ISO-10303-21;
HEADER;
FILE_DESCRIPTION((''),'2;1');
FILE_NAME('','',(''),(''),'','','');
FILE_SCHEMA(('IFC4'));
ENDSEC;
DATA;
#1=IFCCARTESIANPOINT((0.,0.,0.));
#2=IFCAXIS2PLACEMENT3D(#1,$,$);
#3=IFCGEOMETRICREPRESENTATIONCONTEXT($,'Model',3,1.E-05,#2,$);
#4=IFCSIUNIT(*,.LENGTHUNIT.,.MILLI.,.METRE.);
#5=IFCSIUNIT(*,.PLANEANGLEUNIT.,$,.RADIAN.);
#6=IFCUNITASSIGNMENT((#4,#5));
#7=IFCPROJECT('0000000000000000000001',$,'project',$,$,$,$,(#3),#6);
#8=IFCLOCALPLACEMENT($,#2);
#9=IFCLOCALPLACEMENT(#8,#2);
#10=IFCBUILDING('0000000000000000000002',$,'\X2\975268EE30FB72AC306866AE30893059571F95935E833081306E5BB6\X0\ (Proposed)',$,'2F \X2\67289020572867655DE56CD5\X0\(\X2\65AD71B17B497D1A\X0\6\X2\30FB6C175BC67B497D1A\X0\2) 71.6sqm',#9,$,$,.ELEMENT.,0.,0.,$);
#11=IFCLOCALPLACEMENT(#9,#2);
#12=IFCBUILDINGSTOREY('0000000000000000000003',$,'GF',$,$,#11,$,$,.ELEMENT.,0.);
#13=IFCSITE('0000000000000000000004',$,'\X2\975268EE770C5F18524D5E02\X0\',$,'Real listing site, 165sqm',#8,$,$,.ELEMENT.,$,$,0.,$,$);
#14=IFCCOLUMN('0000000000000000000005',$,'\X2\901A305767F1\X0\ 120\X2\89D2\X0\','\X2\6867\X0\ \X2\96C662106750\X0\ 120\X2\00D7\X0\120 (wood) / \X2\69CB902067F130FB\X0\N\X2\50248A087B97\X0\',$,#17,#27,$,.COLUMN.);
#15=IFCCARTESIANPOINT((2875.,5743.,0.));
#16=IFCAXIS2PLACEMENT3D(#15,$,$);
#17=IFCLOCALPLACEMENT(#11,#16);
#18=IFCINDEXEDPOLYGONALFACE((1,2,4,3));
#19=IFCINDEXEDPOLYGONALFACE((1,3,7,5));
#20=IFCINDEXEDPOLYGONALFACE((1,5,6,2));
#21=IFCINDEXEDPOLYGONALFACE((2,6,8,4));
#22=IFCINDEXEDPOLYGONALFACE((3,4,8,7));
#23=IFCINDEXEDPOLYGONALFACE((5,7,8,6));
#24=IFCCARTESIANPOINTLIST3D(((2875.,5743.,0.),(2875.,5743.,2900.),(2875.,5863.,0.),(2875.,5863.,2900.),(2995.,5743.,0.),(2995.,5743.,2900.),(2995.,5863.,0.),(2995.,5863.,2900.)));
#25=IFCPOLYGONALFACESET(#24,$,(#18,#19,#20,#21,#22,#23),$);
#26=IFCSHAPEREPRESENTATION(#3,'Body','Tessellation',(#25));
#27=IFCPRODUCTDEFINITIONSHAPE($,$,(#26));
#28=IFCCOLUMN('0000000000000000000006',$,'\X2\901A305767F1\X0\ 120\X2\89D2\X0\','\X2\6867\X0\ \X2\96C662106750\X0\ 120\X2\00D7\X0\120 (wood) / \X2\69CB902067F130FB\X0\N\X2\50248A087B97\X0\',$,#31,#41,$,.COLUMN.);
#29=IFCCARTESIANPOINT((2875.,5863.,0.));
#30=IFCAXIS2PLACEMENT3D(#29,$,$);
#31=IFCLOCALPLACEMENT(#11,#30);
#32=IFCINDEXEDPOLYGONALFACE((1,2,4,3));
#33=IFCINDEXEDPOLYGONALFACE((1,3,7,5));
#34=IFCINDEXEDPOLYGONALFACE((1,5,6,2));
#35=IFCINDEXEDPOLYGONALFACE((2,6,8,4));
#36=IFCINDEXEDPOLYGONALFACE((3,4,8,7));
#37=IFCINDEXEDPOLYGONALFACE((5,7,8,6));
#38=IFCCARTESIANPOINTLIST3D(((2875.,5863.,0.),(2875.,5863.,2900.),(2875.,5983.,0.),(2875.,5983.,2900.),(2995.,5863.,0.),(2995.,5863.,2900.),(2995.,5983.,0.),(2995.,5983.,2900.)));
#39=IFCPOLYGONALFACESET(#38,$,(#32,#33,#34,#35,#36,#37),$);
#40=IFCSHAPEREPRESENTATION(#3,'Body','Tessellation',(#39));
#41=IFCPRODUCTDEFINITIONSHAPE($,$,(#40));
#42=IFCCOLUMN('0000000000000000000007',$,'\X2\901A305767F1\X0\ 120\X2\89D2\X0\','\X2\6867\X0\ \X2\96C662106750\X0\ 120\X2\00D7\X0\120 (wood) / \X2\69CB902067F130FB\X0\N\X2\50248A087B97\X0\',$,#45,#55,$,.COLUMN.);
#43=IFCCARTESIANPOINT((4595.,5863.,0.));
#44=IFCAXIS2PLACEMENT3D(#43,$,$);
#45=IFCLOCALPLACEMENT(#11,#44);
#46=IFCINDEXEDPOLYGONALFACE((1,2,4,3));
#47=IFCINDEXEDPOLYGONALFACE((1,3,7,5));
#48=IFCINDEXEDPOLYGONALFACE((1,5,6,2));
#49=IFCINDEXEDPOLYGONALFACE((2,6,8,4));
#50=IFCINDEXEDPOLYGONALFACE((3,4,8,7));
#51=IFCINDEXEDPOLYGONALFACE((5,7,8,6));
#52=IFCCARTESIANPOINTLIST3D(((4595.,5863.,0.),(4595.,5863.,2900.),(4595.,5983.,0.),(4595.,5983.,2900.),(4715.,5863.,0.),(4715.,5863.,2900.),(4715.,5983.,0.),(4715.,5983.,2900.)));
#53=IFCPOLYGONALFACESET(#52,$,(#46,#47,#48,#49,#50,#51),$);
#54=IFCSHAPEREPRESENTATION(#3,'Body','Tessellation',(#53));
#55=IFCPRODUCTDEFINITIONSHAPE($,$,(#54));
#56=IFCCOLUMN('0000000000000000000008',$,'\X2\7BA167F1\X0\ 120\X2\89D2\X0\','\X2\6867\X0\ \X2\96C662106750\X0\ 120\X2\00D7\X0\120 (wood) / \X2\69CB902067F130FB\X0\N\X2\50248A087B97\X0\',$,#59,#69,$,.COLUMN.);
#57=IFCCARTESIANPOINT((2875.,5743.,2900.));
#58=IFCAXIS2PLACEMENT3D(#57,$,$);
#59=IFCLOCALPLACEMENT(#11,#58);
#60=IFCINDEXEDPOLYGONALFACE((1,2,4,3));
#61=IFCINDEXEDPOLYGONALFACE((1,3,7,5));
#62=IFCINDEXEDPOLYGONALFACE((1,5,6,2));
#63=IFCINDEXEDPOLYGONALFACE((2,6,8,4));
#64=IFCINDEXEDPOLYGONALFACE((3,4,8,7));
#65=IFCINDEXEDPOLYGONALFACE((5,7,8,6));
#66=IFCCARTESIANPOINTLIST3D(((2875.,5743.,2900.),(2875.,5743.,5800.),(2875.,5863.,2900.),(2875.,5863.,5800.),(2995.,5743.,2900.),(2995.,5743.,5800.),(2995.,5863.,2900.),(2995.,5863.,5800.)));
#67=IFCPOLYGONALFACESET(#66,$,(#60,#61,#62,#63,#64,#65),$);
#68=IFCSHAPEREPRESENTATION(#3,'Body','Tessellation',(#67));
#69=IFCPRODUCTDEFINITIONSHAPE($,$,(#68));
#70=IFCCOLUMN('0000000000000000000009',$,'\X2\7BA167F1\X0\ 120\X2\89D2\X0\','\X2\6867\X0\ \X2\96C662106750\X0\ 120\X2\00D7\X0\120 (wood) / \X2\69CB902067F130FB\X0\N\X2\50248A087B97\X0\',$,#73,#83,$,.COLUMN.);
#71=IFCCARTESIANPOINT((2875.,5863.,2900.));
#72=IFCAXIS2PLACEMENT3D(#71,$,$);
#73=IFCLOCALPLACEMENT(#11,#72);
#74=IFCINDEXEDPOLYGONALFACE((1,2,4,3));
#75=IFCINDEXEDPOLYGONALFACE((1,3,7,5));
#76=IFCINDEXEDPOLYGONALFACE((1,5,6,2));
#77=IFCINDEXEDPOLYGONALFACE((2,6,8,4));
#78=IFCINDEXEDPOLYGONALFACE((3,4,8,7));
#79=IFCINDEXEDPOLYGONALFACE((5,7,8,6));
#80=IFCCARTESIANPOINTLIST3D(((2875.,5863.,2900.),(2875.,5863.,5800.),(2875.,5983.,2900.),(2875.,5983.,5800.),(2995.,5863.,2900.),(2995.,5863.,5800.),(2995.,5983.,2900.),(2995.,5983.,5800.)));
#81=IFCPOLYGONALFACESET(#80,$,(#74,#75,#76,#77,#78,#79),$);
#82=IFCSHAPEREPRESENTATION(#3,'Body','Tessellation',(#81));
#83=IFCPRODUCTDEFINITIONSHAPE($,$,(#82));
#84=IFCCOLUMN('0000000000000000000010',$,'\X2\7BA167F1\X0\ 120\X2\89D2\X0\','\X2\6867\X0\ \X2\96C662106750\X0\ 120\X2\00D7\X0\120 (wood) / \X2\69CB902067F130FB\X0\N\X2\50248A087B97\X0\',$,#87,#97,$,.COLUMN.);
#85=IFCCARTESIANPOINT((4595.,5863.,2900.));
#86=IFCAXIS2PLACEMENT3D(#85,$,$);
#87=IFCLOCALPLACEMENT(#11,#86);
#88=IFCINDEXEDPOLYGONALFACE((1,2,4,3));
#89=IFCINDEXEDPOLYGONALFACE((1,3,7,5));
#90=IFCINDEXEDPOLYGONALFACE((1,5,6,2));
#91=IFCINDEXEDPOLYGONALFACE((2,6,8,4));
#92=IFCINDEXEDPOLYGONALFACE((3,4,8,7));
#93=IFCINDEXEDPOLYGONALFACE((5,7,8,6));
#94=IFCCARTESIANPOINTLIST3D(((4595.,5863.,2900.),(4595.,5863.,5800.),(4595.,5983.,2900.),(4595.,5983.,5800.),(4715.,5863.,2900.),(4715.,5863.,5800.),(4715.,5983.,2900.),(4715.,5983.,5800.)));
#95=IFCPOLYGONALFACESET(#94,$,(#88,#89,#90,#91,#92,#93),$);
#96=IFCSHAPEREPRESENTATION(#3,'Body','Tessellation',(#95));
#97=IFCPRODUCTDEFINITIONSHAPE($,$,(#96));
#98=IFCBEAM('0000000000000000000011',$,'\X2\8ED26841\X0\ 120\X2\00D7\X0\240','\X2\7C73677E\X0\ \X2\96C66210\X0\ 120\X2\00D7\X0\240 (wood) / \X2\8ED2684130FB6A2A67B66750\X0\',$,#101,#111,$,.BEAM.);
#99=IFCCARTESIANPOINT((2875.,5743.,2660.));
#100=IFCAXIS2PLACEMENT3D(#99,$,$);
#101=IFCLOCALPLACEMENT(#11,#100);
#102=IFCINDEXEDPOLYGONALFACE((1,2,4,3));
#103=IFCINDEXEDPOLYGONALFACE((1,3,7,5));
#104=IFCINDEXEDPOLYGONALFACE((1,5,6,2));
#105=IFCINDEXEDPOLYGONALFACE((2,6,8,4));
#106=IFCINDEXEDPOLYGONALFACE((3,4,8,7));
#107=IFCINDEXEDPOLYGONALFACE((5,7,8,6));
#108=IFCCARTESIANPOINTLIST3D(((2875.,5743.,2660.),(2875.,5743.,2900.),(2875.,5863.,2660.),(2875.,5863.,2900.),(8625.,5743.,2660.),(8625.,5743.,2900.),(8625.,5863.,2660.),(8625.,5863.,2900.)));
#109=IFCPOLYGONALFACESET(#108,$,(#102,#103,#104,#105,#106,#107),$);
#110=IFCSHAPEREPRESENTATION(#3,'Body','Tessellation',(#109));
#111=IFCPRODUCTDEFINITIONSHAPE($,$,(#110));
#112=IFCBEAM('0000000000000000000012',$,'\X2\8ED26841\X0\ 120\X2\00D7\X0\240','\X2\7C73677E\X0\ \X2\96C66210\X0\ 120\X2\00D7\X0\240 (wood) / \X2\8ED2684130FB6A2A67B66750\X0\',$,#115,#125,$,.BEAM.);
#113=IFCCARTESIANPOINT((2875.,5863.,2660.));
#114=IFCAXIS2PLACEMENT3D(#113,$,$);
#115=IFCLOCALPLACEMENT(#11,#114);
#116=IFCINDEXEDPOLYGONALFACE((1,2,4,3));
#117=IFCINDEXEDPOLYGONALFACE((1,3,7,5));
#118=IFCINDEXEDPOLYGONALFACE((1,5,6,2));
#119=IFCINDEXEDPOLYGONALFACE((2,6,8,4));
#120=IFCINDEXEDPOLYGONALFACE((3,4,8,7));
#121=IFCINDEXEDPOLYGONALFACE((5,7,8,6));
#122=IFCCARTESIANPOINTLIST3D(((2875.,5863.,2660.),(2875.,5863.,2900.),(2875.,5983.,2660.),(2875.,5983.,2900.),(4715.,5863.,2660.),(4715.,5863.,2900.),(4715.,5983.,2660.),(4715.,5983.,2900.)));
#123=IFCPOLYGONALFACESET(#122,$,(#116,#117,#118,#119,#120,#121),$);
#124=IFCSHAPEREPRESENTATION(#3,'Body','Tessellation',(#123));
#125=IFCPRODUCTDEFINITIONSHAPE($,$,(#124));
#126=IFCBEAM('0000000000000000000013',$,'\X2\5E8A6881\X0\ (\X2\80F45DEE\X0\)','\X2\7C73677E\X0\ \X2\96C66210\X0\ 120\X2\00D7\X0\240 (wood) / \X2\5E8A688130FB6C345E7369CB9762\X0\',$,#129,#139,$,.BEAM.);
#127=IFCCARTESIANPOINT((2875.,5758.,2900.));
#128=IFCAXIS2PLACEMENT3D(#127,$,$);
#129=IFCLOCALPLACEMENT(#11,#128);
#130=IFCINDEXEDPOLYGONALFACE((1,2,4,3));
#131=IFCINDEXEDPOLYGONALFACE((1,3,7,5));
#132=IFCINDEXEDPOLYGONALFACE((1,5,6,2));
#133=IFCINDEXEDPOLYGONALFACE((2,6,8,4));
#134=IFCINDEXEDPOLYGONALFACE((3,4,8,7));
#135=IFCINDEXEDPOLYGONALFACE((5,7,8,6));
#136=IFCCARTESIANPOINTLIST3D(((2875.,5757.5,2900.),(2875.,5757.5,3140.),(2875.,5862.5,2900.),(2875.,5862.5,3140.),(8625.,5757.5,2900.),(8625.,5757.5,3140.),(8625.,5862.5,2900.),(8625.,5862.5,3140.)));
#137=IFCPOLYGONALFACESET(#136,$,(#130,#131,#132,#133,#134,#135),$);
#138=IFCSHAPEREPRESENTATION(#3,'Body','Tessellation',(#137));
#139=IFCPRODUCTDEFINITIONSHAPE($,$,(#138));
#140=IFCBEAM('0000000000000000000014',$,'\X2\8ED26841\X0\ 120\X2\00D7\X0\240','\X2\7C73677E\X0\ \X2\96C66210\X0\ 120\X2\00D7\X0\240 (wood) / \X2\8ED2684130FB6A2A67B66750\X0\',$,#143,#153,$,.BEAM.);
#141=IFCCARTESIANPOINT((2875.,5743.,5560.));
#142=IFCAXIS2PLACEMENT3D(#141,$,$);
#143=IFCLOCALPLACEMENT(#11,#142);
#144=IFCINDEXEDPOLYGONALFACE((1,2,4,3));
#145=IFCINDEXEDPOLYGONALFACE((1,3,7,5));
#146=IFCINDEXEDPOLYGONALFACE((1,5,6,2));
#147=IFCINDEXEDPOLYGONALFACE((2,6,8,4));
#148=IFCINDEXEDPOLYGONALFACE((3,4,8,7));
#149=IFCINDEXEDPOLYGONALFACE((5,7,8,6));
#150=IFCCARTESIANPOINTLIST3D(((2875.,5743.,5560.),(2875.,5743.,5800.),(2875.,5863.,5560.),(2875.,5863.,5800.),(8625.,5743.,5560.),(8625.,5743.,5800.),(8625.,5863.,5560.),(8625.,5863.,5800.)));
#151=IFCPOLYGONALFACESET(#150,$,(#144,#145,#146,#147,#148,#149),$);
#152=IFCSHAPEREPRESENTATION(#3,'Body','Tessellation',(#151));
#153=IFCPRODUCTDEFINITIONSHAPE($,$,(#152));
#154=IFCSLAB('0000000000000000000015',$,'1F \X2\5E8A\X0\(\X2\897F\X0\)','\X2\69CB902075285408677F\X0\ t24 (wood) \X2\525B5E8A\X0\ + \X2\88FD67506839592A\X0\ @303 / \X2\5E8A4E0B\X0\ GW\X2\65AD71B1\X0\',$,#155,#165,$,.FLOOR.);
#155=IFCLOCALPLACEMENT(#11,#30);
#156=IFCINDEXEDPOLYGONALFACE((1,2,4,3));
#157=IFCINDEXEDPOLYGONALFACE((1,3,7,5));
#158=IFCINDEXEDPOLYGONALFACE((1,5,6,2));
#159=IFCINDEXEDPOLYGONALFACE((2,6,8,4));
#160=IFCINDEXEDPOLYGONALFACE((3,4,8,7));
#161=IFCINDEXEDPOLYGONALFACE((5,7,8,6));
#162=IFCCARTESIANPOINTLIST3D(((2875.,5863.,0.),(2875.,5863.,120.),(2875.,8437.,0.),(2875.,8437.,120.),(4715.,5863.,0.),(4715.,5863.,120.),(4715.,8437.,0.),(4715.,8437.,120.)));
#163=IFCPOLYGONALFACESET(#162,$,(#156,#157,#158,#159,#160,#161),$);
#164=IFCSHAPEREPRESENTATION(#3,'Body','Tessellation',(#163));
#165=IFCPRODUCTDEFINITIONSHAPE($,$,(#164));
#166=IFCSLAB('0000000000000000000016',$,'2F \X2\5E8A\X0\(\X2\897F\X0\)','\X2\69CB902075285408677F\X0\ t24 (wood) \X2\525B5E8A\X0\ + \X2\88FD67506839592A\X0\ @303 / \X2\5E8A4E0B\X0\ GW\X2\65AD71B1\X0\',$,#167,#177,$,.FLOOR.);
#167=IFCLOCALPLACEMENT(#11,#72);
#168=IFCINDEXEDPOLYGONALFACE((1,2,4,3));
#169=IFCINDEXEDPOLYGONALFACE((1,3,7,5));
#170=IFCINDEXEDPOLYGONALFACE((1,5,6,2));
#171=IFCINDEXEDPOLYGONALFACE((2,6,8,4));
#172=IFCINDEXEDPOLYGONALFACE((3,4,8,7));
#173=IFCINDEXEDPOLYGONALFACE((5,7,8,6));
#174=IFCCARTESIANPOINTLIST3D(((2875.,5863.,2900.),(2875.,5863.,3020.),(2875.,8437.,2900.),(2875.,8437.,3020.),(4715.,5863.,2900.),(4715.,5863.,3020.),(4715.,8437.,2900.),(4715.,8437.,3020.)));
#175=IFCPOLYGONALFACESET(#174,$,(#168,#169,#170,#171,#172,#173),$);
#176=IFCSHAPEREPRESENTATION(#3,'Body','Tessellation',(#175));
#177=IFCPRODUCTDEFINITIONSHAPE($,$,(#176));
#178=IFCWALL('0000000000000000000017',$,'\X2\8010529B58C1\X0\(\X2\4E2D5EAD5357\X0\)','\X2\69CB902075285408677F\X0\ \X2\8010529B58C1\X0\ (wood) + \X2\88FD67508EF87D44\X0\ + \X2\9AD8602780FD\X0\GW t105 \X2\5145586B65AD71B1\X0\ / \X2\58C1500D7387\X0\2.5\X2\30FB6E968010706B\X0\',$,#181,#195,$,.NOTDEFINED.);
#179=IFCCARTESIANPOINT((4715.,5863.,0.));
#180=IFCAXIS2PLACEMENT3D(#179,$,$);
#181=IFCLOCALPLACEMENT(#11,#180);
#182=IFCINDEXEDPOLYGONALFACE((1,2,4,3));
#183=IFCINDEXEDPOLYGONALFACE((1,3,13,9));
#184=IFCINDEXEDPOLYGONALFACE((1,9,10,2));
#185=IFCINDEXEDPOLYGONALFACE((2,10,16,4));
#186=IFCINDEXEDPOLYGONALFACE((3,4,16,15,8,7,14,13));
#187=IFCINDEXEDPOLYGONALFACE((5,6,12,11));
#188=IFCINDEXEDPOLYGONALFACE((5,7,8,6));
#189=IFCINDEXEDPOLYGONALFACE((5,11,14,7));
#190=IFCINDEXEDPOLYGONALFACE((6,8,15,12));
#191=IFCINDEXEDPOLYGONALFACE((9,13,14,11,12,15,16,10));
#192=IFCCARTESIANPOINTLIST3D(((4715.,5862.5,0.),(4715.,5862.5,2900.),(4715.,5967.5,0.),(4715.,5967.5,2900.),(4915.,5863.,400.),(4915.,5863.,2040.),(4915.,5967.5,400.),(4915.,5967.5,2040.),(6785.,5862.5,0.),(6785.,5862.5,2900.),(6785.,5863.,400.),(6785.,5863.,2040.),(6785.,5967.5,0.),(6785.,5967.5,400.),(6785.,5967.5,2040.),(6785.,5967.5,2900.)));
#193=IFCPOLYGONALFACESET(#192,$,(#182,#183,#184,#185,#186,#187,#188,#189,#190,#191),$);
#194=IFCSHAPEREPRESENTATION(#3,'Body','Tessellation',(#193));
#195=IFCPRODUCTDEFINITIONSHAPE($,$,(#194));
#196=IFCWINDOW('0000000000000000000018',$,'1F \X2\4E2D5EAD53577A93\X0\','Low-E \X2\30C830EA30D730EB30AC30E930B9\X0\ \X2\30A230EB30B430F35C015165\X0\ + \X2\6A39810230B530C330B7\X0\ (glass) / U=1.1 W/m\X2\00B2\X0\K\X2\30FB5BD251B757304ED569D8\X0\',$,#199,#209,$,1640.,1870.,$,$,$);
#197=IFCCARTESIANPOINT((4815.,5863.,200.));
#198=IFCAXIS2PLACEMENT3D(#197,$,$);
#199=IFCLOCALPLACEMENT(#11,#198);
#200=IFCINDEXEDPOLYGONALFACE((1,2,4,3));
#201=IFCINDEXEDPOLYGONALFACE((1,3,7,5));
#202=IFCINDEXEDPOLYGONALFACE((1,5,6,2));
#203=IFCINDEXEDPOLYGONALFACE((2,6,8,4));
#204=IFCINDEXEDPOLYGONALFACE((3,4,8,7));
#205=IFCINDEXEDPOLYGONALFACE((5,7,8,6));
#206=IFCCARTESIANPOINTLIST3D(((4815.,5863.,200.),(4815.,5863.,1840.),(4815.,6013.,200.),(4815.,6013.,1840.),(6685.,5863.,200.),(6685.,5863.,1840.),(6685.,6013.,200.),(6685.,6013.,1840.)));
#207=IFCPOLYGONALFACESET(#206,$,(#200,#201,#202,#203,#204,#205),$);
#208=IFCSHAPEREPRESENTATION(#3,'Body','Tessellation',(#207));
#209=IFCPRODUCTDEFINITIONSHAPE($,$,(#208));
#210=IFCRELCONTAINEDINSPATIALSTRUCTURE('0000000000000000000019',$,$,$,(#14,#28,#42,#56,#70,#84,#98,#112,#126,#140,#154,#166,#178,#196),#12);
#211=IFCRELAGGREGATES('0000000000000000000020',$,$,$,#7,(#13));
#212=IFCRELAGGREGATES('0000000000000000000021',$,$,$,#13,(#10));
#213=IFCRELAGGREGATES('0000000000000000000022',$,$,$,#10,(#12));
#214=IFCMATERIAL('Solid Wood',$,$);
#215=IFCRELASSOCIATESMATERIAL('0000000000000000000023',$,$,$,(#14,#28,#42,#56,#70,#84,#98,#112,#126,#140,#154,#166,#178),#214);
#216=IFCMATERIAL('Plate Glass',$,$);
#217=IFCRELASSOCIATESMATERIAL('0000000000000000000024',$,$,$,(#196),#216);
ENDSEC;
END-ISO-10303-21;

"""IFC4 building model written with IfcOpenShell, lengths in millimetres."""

from ifc_helpers import new_model, si_unit, frame, frame_2d, origin, place, context, project, spatial, rectangle, extrude, material, element, fill, save


model = new_model("IFC4")

# Units and contexts
model_context = context("Model", 3, precision=1e-05, world=origin())
ifc_project = project(units=[si_unit("LENGTHUNIT", "METRE", prefix="MILLI"), si_unit("PLANEANGLEUNIT", "RADIAN")], contexts=[model_context])

# Site, building, storey
site_placement = place(None, origin())
site = spatial("IfcSite", under=ifc_project, at=site_placement, Name="青森県弘前市", ObjectType="Real listing site, 165sqm", CompositionType="ELEMENT", RefElevation=0.0)
building_placement = place(site_placement, origin())
building = spatial("IfcBuilding", under=site, at=building_placement, Name="青森・犬と暮らす土間広めの家 (Proposed)", ObjectType="2F 木造在来工法(断熱等級6・気密等級2) 71.6sqm", CompositionType="ELEMENT", ElevationOfRefHeight=0.0, ElevationOfTerrain=0.0)
storey_placement = place(building_placement, origin())
storey = spatial("IfcBuildingStorey", under=building, at=storey_placement, Name="GF", CompositionType="ELEMENT", Elevation=0.0)

# Columns
ifc_material_1 = material(Name="Solid Wood")
column_1_placement = place(storey_placement, frame((2875.0, 5743.0, 0.0)))
element("IfcColumn", 1, at=column_1_placement, inside=storey, material=ifc_material_1, Name="通し柱 120角", Description="桧 集成材 120×120 (wood) / 構造柱・N値計算", PredefinedType="COLUMN", context=model_context, shape_type="SweptSolid", body=[
    extrude(rectangle(XDim=120.0, YDim=120.0, at=frame_2d((60.0, 60.0))), frame((2875.0, 5743.0, 0.0)), (0.0, 0.0, 1.0), 2900.0),
])
column_2_placement = place(storey_placement, frame((2875.0, 5863.0, 0.0)))
element("IfcColumn", 2, at=column_2_placement, inside=storey, material=ifc_material_1, Name="通し柱 120角", Description="桧 集成材 120×120 (wood) / 構造柱・N値計算", PredefinedType="COLUMN", context=model_context, shape_type="SweptSolid", body=[
    extrude(rectangle(XDim=120.0, YDim=120.0, at=frame_2d((60.0, 60.0))), frame((2875.0, 5863.0, 0.0)), (0.0, 0.0, 1.0), 2900.0),
])
column_3_placement = place(storey_placement, frame((4595.0, 5863.0, 0.0)))
element("IfcColumn", 3, at=column_3_placement, inside=storey, material=ifc_material_1, Name="通し柱 120角", Description="桧 集成材 120×120 (wood) / 構造柱・N値計算", PredefinedType="COLUMN", context=model_context, shape_type="SweptSolid", body=[
    extrude(rectangle(XDim=120.0, YDim=120.0, at=frame_2d((60.0, 60.0))), frame((4595.0, 5863.0, 0.0)), (0.0, 0.0, 1.0), 2900.0),
])
column_4_placement = place(storey_placement, frame((2875.0, 5743.0, 2900.0)))
element("IfcColumn", 4, at=column_4_placement, inside=storey, material=ifc_material_1, Name="管柱 120角", Description="桧 集成材 120×120 (wood) / 構造柱・N値計算", PredefinedType="COLUMN", context=model_context, shape_type="SweptSolid", body=[
    extrude(rectangle(XDim=120.0, YDim=120.0, at=frame_2d((60.0, 60.0))), frame((2875.0, 5743.0, 2900.0)), (0.0, 0.0, 1.0), 2900.0),
])
column_5_placement = place(storey_placement, frame((2875.0, 5863.0, 2900.0)))
element("IfcColumn", 5, at=column_5_placement, inside=storey, material=ifc_material_1, Name="管柱 120角", Description="桧 集成材 120×120 (wood) / 構造柱・N値計算", PredefinedType="COLUMN", context=model_context, shape_type="SweptSolid", body=[
    extrude(rectangle(XDim=120.0, YDim=120.0, at=frame_2d((60.0, 60.0))), frame((2875.0, 5863.0, 2900.0)), (0.0, 0.0, 1.0), 2900.0),
])
column_6_placement = place(storey_placement, frame((4595.0, 5863.0, 2900.0)))
element("IfcColumn", 6, at=column_6_placement, inside=storey, material=ifc_material_1, Name="管柱 120角", Description="桧 集成材 120×120 (wood) / 構造柱・N値計算", PredefinedType="COLUMN", context=model_context, shape_type="SweptSolid", body=[
    extrude(rectangle(XDim=120.0, YDim=120.0, at=frame_2d((60.0, 60.0))), frame((4595.0, 5863.0, 2900.0)), (0.0, 0.0, 1.0), 2900.0),
])

# Beams
beam_1_placement = place(storey_placement, frame((2875.0, 5743.0, 2660.0)))
element("IfcBeam", 7, at=beam_1_placement, inside=storey, material=ifc_material_1, Name="軒桁 120×240", Description="米松 集成 120×240 (wood) / 軒桁・横架材", PredefinedType="BEAM", context=model_context, shape_type="SweptSolid", body=[
    extrude(rectangle(XDim=5750.0, YDim=120.0, at=frame_2d((2875.0, 60.0))), frame((2875.0, 5743.0, 2660.0)), (0.0, 0.0, 1.0), 240.0),
])
beam_2_placement = place(storey_placement, frame((2875.0, 5863.0, 2660.0)))
element("IfcBeam", 8, at=beam_2_placement, inside=storey, material=ifc_material_1, Name="軒桁 120×240", Description="米松 集成 120×240 (wood) / 軒桁・横架材", PredefinedType="BEAM", context=model_context, shape_type="SweptSolid", body=[
    extrude(rectangle(XDim=1840.0, YDim=120.0, at=frame_2d((920.0, 60.0))), frame((2875.0, 5863.0, 2660.0)), (0.0, 0.0, 1.0), 240.0),
])
beam_3_placement = place(storey_placement, frame((2875.0, 5758.0, 2900.0)))
element("IfcBeam", 9, at=beam_3_placement, inside=storey, material=ifc_material_1, Name="床梁 (胴差)", Description="米松 集成 120×240 (wood) / 床梁・水平構面", PredefinedType="BEAM", context=model_context, shape_type="SweptSolid", body=[
    extrude(rectangle(XDim=5750.0, YDim=105.0, at=frame_2d((2875.0, 52.0))), frame((2875.0, 5758.0, 2900.0)), (0.0, 0.0, 1.0), 240.0),
])
beam_4_placement = place(storey_placement, frame((2875.0, 5743.0, 5560.0)))
element("IfcBeam", 10, at=beam_4_placement, inside=storey, material=ifc_material_1, Name="軒桁 120×240", Description="米松 集成 120×240 (wood) / 軒桁・横架材", PredefinedType="BEAM", context=model_context, shape_type="SweptSolid", body=[
    extrude(rectangle(XDim=5750.0, YDim=120.0, at=frame_2d((2875.0, 60.0))), frame((2875.0, 5743.0, 5560.0)), (0.0, 0.0, 1.0), 240.0),
])

# Slabs
slab_1_placement = place(storey_placement, frame((2875.0, 5863.0, 0.0)))
element("IfcSlab", 11, at=slab_1_placement, inside=storey, material=ifc_material_1, Name="1F 床(西)", Description="構造用合板 t24 (wood) 剛床 + 製材根太 @303 / 床下 GW断熱", PredefinedType="FLOOR", context=model_context, shape_type="SweptSolid", body=[
    extrude(rectangle(XDim=1840.0, YDim=2574.0, at=frame_2d((920.0, 1287.0))), frame((2875.0, 5863.0, 0.0)), (0.0, 0.0, 1.0), 120.0),
])
slab_2_placement = place(storey_placement, frame((2875.0, 5863.0, 2900.0)))
element("IfcSlab", 12, at=slab_2_placement, inside=storey, material=ifc_material_1, Name="2F 床(西)", Description="構造用合板 t24 (wood) 剛床 + 製材根太 @303 / 床下 GW断熱", PredefinedType="FLOOR", context=model_context, shape_type="SweptSolid", body=[
    extrude(rectangle(XDim=1840.0, YDim=2574.0, at=frame_2d((920.0, 1287.0))), frame((2875.0, 5863.0, 2900.0)), (0.0, 0.0, 1.0), 120.0),
])

# Wall, opening, window
wall_1_placement = place(storey_placement, frame((4715.0, 5863.0, 0.0)))
wall_1 = element("IfcWall", 13, at=wall_1_placement, inside=storey, material=ifc_material_1, Name="耐力壁(中庭南)", Description="構造用合板 耐力壁 (wood) + 製材軸組 + 高性能GW t105 充填断熱 / 壁倍率2.5・準耐火", PredefinedType="NOTDEFINED", context=model_context, shape_type="SweptSolid", body=[
    extrude(rectangle(XDim=2070.0, YDim=105.0, at=frame_2d((1035.0, 52.0))), frame((4715.0, 5863.0, 0.0)), (0.0, 0.0, 1.0), 2900.0),
])
opening_placement = place(storey_placement, frame((4815.0, 5863.0, 200.0)))
opening = element("IfcOpeningElement", 14, at=opening_placement, cuts=wall_1, PredefinedType="NOTDEFINED", context=model_context, shape_type="SweptSolid", body=[
    extrude(rectangle(XDim=1870.0, YDim=150.0, at=frame_2d((935.0, 75.0))), frame((4815.0, 5863.0, 200.0)), (0.0, 0.0, 1.0), 1640.0),
])
ifc_material_2 = material(Name="Plate Glass")
window_1_placement = place(storey_placement, frame((4815.0, 5863.0, 200.0)))
window_1 = element("IfcWindow", 15, at=window_1_placement, inside=storey, material=ifc_material_2, Name="1F 中庭南窓", Description="Low-E トリプルガラス アルゴン封入 + 樹脂サッシ (glass) / U=1.1 W/m²K・寒冷地仕様", OverallHeight=1640.0, OverallWidth=1870.0, context=model_context, shape_type="SweptSolid", body=[
    extrude(rectangle(XDim=1870.0, YDim=150.0, at=frame_2d((935.0, 75.0))), frame((4815.0, 5863.0, 200.0)), (0.0, 0.0, 1.0), 1640.0),
])
fill(opening, window_1)

save(model, "model.ifc")
